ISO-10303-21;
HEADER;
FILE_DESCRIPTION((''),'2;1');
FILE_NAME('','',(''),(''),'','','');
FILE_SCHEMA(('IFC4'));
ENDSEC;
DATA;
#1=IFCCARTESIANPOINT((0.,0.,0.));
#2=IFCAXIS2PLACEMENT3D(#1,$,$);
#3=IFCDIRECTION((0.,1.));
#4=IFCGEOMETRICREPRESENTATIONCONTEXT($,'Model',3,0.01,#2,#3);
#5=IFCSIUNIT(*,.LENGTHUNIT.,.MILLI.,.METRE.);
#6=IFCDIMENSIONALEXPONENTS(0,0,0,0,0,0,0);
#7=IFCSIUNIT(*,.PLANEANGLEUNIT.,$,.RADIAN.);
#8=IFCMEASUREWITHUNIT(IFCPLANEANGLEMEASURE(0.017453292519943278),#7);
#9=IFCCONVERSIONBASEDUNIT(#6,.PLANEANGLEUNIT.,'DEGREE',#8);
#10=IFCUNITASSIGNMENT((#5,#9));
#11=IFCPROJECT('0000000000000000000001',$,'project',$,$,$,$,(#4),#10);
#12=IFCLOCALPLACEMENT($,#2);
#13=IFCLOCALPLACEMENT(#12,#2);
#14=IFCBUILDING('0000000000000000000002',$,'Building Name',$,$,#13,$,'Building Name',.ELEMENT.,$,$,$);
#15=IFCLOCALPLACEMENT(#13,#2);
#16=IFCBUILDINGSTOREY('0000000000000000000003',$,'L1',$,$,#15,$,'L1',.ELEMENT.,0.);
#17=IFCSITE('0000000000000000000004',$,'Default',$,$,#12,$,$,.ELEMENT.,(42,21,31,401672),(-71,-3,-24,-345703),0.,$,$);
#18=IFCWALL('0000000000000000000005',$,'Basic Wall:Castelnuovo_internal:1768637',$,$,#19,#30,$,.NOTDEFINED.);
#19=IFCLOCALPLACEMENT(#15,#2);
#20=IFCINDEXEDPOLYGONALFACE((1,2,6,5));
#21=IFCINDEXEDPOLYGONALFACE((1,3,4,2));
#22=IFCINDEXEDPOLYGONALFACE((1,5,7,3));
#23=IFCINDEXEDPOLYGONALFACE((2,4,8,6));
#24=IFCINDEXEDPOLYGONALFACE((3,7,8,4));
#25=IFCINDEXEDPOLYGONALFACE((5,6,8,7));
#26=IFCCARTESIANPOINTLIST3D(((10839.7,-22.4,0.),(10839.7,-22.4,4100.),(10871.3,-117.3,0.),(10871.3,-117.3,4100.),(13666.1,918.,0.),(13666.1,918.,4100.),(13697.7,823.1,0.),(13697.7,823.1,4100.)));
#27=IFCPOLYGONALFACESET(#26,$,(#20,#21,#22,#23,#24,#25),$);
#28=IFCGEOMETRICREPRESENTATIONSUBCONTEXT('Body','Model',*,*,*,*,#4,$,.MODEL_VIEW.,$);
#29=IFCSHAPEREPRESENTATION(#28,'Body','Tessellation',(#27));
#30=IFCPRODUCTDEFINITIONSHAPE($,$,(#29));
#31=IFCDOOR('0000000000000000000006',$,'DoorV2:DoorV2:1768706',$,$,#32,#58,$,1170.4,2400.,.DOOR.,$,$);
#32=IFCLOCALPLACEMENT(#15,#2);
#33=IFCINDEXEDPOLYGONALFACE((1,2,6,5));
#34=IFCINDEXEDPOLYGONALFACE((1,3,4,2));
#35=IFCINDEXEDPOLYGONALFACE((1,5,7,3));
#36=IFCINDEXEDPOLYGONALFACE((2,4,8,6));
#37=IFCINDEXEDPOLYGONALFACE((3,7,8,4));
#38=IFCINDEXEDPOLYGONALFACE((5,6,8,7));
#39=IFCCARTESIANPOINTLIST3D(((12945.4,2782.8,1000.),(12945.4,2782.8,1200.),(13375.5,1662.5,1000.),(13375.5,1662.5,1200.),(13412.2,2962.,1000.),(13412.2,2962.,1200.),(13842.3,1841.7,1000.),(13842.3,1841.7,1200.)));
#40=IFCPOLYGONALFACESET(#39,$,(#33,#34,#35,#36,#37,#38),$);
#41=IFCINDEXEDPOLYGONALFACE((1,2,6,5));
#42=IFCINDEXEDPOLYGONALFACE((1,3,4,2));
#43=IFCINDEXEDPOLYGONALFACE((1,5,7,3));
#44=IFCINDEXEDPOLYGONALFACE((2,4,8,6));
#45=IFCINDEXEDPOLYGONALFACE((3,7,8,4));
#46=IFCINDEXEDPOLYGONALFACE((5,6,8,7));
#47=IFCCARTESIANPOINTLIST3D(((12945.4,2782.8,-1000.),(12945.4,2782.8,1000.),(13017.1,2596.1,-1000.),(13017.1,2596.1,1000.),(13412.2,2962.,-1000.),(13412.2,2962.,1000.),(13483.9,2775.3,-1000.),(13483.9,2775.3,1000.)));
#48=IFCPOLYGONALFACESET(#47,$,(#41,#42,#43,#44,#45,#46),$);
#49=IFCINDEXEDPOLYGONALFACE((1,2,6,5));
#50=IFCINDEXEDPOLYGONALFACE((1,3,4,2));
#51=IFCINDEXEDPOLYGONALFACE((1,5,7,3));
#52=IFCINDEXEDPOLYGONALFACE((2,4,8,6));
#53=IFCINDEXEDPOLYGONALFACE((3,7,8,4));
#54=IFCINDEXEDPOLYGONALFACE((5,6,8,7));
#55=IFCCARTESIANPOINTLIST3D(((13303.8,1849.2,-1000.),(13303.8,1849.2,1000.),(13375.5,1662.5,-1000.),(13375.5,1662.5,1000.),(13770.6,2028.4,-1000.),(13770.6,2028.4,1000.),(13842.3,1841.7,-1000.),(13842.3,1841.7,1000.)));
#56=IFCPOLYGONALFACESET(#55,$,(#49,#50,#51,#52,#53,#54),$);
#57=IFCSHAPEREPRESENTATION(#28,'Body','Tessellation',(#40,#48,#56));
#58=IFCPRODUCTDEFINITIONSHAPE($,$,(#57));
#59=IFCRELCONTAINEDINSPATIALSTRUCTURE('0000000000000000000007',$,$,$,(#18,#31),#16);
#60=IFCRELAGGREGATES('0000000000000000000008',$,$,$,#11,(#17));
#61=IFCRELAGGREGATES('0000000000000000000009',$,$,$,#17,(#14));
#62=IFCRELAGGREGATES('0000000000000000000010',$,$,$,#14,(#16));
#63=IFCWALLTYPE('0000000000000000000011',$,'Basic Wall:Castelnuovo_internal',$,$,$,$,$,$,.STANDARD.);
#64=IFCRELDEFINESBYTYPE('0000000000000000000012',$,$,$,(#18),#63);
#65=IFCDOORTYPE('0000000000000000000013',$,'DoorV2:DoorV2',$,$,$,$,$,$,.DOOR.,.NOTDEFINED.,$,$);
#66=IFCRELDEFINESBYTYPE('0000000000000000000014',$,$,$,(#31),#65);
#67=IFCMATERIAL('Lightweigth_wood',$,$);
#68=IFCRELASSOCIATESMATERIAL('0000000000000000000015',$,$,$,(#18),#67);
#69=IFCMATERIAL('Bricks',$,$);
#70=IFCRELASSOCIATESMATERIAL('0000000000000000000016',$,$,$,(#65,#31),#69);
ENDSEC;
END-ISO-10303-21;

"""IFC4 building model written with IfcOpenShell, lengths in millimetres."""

from ifc_helpers import new_model, entity, si_unit, converted_unit, direction, frame, origin, place, context, subcontext, project, spatial, indexed_curve, outline, extrude, source, transform, mapped, material, type_object, type_shapes, element, save


model = new_model("IFC4")

# Units and contexts
model_context = context("Model", 3, precision=0.01, world=origin(), true_north=direction((0.0, 1.0)))
body_context = subcontext(model_context, "Body", "Model", "MODEL_VIEW")
ifc_project = project(units=[si_unit("LENGTHUNIT", "METRE", prefix="MILLI"), converted_unit("PLANEANGLEUNIT", "DEGREE", entity("IfcPlaneAngleMeasure", 0.017453292519943278), si_unit("PLANEANGLEUNIT", "RADIAN"), dimensions=[0, 0, 0, 0, 0, 0, 0])], contexts=[model_context])

# Site, building, storey
site_placement = place(None, origin())
site = spatial("IfcSite", under=ifc_project, at=site_placement, Name="Default", CompositionType="ELEMENT", RefLatitude=(42, 21, 31, 401672), RefLongitude=(-71, -3, -24, -345703), RefElevation=0.0)
building_placement = place(site_placement, origin())
building = spatial("IfcBuilding", under=site, at=building_placement, Name="Building Name", LongName="Building Name", CompositionType="ELEMENT")
storey_placement = place(building_placement, origin())
storey = spatial("IfcBuildingStorey", under=building, at=storey_placement, Name="L1", LongName="L1", CompositionType="ELEMENT", Elevation=0.0)

# Wall
ifc_material_1 = material(Name="Lightweigth_wood")
wall_type_1 = type_object("IfcWallType", Name="Basic Wall:Castelnuovo_internal", PredefinedType="STANDARD")
wall_1_placement = place(storey_placement, frame((13681.9, 870.6, 0.0), z_axis=(0.0, 0.0, 1.0), x_axis=(-0.948854, -0.315716, 0.0)))
element("IfcWall", 1, at=wall_1_placement, inside=storey, type_object=wall_type_1, material=ifc_material_1, Name="Basic Wall:Castelnuovo_internal:1768637", PredefinedType="NOTDEFINED", context=body_context, shape_type="SweptSolid", body=[
    extrude(outline(indexed_curve([(2978.8, 50.0), (0.0, 50.0), (0.0, -50.0), (2978.8, -50.0), (2978.8, 50.0)], self_intersect=False)), origin(), (0.0, 0.0, 1.0), 4100.0),
])

# Door
ifc_material_2 = material(Name="Bricks")
door_type_1 = type_object("IfcDoorType", Name="DoorV2:DoorV2", OperationType="NOTDEFINED", PredefinedType="DOOR", material=ifc_material_2)
shared_shape_1 = source(origin(), body_context, "Body", "SweptSolid", [
    extrude(outline(indexed_curve([(-250.0, -600.0), (250.0, -600.0), (250.0, 600.0), (-250.0, 600.0), (-250.0, -600.0)], self_intersect=False)), frame((0.0, 0.0, 2000.0), z_axis=(0.0, 0.0, 1.0), x_axis=(0.0, 1.0, 0.0)), (0.0, 0.0, 1.0), 200.0),
    extrude(outline(indexed_curve([(-250.0, -100.0), (250.0, -100.0), (250.0, 100.0), (-250.0, 100.0), (-250.0, -100.0)], self_intersect=False)), frame((500.0, 0.0, 0.0), z_axis=(0.0, 0.0, 1.0), x_axis=(0.0, 1.0, 0.0)), (0.0, 0.0, 1.0), 2000.0),
    extrude(outline(indexed_curve([(-250.0, -100.0), (250.0, -100.0), (250.0, 100.0), (-250.0, 100.0), (-250.0, -100.0)], self_intersect=False)), frame((-500.0, 0.0, 0.0), z_axis=(0.0, 0.0, 1.0), x_axis=(0.0, 1.0, 0.0)), (0.0, 0.0, 1.0), 2000.0),
])
type_shapes(door_type_1, [shared_shape_1])
door_1_placement = place(storey_placement, frame((13393.9, 2312.2, -1000.0), z_axis=(0.0, 0.0, 1.0), x_axis=(-0.358368, 0.93358, 0.0)))
element("IfcDoor", 2, at=door_1_placement, inside=storey, type_object=door_type_1, material=ifc_material_2, Name="DoorV2:DoorV2:1768706", OverallHeight=1170.4, OverallWidth=2400.0, PredefinedType="DOOR", context=body_context, shape_type="MappedRepresentation", body=[
    mapped(shared_shape_1, transform((0.0, 0.0, 0.0), scale=1.0)),
])

save(model, "model.ifc")
